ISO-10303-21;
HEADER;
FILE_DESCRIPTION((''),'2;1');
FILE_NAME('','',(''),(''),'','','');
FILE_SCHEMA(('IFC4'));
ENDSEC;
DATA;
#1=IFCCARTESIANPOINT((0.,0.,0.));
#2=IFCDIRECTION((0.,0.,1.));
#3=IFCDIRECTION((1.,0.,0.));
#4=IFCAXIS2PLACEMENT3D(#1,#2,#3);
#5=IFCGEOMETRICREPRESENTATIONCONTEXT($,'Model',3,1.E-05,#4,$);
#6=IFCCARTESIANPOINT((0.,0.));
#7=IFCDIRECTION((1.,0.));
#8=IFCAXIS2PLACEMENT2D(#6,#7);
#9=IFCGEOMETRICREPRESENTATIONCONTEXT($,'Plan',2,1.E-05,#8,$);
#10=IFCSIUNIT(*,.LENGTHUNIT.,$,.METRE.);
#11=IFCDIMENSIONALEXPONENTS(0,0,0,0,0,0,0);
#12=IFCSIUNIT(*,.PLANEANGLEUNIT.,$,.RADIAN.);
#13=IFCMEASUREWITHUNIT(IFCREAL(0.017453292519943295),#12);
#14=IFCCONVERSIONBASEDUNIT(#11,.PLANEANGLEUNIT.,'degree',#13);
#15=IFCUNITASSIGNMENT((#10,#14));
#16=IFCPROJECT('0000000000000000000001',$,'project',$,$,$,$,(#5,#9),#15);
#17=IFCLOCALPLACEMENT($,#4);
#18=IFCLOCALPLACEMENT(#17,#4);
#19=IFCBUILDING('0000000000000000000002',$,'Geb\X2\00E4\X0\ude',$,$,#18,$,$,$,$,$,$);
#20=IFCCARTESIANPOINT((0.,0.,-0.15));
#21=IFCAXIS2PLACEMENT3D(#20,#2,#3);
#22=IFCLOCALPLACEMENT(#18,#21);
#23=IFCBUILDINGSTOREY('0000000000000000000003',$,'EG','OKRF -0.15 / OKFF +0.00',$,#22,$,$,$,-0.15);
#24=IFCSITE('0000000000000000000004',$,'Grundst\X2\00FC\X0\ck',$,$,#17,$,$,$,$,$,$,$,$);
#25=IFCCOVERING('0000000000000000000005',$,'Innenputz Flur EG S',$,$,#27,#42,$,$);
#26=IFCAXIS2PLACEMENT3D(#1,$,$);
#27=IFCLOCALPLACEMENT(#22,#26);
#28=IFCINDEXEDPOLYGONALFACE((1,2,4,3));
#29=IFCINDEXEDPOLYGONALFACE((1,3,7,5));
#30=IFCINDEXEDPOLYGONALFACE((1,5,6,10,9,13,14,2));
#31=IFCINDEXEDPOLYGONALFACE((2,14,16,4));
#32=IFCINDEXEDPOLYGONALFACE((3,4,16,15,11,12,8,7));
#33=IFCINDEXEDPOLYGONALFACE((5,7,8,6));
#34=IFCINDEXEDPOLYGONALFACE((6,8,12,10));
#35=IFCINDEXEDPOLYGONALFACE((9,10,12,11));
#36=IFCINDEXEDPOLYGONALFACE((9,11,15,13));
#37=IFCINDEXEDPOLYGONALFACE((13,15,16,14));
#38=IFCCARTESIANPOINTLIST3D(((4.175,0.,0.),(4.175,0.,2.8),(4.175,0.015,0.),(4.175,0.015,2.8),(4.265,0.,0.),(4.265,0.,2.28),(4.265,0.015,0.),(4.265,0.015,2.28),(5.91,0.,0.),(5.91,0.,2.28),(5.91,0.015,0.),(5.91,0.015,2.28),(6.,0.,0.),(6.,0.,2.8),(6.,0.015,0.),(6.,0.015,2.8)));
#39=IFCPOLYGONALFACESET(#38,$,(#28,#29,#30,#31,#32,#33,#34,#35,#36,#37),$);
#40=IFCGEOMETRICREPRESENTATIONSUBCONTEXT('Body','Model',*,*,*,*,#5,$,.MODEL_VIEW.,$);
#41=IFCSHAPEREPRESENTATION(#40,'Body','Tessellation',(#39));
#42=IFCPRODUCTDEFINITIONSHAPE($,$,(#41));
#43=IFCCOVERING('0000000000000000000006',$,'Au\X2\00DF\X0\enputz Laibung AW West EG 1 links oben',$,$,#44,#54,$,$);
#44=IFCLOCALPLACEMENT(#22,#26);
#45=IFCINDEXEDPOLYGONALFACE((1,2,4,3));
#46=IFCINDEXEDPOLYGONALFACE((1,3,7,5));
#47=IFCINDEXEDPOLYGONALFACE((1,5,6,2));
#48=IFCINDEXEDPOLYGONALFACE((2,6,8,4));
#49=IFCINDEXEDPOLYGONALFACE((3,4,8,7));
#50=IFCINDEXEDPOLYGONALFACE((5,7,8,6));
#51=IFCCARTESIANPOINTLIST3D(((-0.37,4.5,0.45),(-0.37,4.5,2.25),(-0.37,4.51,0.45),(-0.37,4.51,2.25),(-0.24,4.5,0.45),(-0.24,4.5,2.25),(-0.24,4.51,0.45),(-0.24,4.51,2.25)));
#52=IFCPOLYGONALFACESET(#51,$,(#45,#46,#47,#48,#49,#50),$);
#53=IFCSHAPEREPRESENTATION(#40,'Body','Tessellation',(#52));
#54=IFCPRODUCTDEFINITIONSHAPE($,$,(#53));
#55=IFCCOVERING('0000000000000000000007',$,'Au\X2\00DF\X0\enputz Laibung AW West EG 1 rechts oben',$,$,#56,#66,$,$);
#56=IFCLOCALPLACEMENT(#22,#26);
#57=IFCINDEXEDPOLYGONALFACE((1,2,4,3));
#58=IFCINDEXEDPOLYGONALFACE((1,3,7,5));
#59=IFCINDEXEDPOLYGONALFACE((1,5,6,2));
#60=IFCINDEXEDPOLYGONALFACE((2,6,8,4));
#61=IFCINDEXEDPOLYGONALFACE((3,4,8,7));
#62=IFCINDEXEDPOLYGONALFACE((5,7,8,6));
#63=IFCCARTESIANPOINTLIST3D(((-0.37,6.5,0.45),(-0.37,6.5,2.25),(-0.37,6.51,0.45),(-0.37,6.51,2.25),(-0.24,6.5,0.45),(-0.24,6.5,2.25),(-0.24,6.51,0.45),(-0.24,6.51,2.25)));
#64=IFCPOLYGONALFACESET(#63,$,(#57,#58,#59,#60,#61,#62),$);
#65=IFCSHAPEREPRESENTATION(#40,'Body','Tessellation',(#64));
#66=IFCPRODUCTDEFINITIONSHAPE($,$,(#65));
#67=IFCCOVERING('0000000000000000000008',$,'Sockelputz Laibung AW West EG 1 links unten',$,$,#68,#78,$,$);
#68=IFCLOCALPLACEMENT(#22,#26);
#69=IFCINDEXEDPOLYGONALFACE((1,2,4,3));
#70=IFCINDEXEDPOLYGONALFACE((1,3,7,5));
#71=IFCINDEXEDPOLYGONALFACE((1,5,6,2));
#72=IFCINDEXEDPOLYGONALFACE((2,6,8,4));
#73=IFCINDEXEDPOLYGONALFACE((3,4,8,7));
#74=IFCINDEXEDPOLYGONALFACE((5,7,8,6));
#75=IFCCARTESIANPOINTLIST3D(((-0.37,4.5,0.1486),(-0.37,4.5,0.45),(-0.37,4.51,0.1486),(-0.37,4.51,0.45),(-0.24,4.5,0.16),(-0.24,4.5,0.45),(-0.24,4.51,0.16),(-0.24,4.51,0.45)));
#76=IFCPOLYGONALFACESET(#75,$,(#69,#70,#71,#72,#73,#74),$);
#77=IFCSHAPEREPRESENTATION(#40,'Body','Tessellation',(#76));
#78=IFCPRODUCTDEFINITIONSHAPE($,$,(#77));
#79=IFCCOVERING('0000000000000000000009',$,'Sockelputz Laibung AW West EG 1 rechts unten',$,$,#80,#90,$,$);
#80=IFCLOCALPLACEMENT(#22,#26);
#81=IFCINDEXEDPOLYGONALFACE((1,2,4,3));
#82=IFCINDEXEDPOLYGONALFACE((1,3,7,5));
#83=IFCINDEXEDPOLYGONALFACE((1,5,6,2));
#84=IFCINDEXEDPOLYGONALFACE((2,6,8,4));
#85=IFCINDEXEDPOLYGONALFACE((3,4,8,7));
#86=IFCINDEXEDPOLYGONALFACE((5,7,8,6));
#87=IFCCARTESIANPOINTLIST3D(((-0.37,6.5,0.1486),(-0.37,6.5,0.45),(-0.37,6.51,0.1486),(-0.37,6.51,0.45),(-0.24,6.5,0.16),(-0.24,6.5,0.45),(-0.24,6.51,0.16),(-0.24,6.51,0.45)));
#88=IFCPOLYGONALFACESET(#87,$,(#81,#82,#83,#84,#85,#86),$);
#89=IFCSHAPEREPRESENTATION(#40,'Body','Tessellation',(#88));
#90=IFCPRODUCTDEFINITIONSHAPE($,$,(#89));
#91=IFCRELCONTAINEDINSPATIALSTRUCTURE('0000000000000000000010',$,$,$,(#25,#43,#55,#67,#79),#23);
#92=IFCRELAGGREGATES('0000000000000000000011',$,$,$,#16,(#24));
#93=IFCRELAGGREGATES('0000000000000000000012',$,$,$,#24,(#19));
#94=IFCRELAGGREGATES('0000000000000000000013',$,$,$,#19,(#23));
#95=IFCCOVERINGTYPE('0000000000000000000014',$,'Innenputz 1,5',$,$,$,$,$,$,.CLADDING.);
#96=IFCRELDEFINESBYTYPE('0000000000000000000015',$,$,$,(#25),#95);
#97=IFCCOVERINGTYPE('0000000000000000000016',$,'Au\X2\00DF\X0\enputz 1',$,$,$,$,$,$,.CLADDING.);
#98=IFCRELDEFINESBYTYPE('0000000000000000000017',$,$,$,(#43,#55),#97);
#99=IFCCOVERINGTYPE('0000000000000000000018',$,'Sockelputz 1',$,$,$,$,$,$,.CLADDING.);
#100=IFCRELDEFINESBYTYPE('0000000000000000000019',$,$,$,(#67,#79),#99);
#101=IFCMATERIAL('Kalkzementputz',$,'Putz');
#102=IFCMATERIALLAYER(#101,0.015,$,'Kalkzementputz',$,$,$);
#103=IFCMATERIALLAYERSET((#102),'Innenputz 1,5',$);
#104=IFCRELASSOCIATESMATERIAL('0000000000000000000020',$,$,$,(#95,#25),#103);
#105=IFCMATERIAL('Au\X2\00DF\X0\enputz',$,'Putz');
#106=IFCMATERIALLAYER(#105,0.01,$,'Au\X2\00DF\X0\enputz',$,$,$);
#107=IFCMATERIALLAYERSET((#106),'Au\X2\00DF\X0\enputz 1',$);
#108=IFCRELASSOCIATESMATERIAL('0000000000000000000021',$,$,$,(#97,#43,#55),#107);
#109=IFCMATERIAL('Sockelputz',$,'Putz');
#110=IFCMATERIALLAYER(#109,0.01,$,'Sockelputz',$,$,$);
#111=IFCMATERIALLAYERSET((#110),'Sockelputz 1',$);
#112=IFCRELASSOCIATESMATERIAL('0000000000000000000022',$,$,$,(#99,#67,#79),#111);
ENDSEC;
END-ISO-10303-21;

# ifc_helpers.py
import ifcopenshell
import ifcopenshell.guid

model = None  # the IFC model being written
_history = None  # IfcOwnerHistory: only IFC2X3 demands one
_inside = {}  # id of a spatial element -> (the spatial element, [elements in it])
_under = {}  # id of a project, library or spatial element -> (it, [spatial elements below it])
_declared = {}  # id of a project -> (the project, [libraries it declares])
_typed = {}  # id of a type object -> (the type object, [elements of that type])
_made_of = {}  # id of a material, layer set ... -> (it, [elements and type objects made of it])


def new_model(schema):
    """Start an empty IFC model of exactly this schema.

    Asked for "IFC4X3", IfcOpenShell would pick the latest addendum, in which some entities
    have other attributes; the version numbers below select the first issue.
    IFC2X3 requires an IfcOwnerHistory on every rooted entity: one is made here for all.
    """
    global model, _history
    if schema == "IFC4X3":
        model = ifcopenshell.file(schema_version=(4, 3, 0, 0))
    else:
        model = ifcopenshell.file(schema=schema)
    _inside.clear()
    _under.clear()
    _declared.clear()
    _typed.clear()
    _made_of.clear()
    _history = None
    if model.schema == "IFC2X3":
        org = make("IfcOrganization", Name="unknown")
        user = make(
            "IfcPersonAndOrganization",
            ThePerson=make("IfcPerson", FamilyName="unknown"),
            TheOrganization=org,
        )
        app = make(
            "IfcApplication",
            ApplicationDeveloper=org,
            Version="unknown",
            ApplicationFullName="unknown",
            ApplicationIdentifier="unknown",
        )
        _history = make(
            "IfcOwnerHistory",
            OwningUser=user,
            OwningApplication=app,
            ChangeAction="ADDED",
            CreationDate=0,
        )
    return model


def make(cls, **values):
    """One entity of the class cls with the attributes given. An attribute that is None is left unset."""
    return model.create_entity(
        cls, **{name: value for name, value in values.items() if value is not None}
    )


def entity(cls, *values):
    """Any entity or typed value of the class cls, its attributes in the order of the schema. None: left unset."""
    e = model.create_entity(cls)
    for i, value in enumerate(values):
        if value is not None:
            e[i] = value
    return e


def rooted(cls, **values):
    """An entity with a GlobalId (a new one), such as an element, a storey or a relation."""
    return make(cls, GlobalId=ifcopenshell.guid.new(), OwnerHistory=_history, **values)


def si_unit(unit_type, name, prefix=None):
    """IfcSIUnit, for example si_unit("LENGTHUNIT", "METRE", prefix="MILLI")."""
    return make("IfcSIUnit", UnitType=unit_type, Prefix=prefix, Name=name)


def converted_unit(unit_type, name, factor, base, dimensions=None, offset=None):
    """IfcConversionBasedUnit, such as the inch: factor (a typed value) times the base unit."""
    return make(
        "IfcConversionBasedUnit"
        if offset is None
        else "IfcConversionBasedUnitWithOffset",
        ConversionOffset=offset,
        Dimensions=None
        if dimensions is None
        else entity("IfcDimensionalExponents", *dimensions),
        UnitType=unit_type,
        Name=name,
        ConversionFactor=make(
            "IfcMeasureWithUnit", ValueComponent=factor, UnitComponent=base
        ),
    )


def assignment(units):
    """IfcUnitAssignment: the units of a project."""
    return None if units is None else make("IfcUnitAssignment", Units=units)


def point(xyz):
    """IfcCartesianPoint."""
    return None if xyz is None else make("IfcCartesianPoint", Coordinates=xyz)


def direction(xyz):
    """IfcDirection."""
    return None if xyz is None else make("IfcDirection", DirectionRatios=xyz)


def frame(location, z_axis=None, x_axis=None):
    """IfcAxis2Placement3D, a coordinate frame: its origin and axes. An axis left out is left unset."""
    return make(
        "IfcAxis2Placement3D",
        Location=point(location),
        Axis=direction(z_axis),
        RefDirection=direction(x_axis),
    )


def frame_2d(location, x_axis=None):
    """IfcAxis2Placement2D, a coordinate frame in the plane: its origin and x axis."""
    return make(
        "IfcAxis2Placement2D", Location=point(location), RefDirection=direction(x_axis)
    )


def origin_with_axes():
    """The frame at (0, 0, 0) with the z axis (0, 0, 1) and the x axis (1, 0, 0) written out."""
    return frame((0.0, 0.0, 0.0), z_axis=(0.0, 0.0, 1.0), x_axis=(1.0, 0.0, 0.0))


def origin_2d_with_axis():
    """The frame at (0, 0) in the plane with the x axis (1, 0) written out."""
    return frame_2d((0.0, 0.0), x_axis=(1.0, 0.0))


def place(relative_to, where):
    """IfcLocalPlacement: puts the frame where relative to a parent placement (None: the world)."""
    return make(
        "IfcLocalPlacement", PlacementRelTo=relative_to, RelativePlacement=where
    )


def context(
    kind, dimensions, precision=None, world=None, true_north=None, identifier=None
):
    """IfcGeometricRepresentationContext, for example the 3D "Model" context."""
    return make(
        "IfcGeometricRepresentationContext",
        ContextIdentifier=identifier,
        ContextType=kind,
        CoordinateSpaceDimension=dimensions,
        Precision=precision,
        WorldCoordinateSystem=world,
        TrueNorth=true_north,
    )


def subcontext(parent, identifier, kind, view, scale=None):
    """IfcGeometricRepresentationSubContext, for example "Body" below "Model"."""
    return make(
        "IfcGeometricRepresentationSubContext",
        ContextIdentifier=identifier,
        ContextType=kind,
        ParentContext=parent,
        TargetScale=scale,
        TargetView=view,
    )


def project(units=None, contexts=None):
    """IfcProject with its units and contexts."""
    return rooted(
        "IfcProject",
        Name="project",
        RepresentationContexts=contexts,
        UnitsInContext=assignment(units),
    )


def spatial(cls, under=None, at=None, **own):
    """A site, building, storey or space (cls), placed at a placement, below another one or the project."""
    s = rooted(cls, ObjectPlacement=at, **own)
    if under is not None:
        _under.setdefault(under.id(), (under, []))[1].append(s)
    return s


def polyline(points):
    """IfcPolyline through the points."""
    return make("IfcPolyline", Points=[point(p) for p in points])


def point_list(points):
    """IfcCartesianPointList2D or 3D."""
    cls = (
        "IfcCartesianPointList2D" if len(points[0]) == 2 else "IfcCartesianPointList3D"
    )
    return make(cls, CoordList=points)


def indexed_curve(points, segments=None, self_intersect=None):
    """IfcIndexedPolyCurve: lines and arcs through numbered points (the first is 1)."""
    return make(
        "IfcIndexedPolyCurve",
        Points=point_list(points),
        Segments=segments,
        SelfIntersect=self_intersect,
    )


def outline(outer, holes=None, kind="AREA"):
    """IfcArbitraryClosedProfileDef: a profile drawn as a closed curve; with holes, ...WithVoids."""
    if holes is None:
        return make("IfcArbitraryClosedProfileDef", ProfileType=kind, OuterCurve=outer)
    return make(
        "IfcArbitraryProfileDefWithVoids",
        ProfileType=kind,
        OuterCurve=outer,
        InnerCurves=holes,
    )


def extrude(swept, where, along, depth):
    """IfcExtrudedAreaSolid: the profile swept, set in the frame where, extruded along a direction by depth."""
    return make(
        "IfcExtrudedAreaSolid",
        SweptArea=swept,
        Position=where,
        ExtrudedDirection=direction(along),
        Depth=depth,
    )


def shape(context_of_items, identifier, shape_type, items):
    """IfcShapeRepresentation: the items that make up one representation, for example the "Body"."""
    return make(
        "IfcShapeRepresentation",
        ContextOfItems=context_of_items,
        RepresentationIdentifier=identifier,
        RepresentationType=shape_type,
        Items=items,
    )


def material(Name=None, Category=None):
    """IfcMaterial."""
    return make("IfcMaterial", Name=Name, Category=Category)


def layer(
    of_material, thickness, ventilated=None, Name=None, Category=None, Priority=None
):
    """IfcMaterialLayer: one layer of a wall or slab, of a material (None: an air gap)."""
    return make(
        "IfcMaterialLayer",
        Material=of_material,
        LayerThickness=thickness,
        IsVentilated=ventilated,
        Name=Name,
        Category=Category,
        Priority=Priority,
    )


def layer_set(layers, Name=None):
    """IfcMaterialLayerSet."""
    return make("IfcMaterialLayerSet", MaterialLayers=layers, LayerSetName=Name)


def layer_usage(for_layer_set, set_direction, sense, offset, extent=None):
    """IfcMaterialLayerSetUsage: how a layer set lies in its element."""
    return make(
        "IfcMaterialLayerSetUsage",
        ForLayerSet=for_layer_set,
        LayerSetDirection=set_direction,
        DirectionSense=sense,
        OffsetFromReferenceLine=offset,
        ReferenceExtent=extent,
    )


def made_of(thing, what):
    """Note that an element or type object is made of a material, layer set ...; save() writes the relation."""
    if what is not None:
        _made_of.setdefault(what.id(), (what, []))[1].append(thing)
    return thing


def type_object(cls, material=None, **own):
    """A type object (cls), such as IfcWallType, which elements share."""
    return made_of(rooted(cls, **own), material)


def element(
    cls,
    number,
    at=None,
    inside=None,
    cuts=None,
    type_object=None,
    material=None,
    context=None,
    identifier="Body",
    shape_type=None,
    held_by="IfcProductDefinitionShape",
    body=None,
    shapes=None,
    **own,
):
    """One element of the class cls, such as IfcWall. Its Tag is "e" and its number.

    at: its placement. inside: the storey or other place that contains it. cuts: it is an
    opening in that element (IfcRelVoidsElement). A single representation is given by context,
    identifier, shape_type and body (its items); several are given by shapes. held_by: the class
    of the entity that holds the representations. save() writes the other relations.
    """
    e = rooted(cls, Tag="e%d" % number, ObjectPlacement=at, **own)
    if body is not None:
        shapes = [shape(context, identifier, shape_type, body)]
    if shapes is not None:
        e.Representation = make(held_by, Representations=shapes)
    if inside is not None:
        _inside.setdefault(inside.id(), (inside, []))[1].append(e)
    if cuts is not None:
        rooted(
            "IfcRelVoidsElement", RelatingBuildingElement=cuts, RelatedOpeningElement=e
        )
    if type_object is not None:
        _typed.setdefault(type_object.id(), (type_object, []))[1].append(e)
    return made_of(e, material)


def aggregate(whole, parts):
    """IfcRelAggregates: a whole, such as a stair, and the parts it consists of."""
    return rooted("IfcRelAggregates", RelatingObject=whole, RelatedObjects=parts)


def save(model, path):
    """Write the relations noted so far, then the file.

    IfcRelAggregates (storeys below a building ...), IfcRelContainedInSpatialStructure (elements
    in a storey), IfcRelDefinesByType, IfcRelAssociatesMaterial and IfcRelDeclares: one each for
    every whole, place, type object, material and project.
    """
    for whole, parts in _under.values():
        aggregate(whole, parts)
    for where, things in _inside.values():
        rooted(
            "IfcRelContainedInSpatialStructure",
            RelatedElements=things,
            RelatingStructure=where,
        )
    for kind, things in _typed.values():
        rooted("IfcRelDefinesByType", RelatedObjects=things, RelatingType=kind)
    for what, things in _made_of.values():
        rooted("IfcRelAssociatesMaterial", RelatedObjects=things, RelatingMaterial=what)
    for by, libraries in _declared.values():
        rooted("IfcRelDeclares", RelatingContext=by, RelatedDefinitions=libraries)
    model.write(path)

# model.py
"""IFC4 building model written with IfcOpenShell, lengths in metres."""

from ifc_helpers import new_model, entity, si_unit, converted_unit, frame, origin_with_axes, origin_2d_with_axis, place, context, subcontext, project, spatial, polyline, indexed_curve, outline, extrude, material, layer, layer_set, layer_usage, type_object, element, save


model = new_model("IFC4")

# Units and contexts
model_context = context("Model", 3, precision=1e-05, world=origin_with_axes())
plan_context = context("Plan", 2, precision=1e-05, world=origin_2d_with_axis())
body_context = subcontext(model_context, "Body", "Model", "MODEL_VIEW")
ifc_project = project(units=[si_unit("LENGTHUNIT", "METRE"), converted_unit("PLANEANGLEUNIT", "degree", entity("IfcReal", 0.017453292519943295), si_unit("PLANEANGLEUNIT", "RADIAN"), dimensions=[0, 0, 0, 0, 0, 0, 0])], contexts=[model_context, plan_context])

# Site, building, storey
site_placement = place(None, origin_with_axes())
site = spatial("IfcSite", under=ifc_project, at=site_placement, Name="Grundstück")
building_placement = place(site_placement, origin_with_axes())
building = spatial("IfcBuilding", under=site, at=building_placement, Name="Gebäude")
storey_placement = place(building_placement, frame((0.0, 0.0, -0.15), z_axis=(0.0, 0.0, 1.0), x_axis=(1.0, 0.0, 0.0)))
storey = spatial("IfcBuildingStorey", under=building, at=storey_placement, Name="EG", Description="OKRF -0.15 / OKFF +0.00", Elevation=-0.15)

# Shared definitions
ifc_material_1 = material(Name="Kalkzementputz", Category="Putz")
ifc_layer_1 = layer(ifc_material_1, 0.015, Name="Kalkzementputz")
ifc_layer_set_1 = layer_set([ifc_layer_1], Name="Innenputz 1,5")
covering_type_1 = type_object("IfcCoveringType", Name="Innenputz 1,5", PredefinedType="CLADDING", material=ifc_layer_set_1)

# Covering, opening
ifc_layer_usage_1 = layer_usage(ifc_layer_set_1, "AXIS2", "POSITIVE", 0.0)
covering_1_placement = place(storey_placement, frame((4.175, 0.0, 0.0), z_axis=(0.0, 0.0, 1.0), x_axis=(1.0, 0.0, 0.0)))
covering_1 = element("IfcCovering", 1, at=covering_1_placement, inside=storey, type_object=covering_type_1, material=ifc_layer_usage_1, Name="Innenputz Flur EG S", context=body_context, shape_type="SweptSolid", body=[
    extrude(outline(indexed_curve([(0.0, 0.0), (0.0, 0.015), (1.825, 0.015), (1.825, 0.0), (0.0, 0.0)], self_intersect=False)), origin_with_axes(), (0.0, 0.0, 1.0), 2.8),
])
opening_1_placement = place(covering_1_placement, frame((0.09, -0.05, 0.0), z_axis=(0.0, 0.0, 1.0), x_axis=(1.0, 0.0, 0.0)))
element("IfcOpeningElement", 2, at=opening_1_placement, cuts=covering_1, context=body_context, shape_type="SweptSolid", body=[
    extrude(outline(indexed_curve([(0.0, 0.0), (0.0, 0.115), (1.645, 0.115), (1.645, 0.0), (0.0, 0.0)], self_intersect=False)), origin_with_axes(), (0.0, 0.0, 1.0), 2.28),
])

# Coverings
ifc_material_2 = material(Name="Außenputz", Category="Putz")
ifc_layer_2 = layer(ifc_material_2, 0.01, Name="Außenputz")
ifc_layer_set_2 = layer_set([ifc_layer_2], Name="Außenputz 1")
ifc_layer_usage_2 = layer_usage(ifc_layer_set_2, "AXIS1", "POSITIVE", 4.5)
covering_type_2 = type_object("IfcCoveringType", Name="Außenputz 1", PredefinedType="CLADDING", material=ifc_layer_set_2)
covering_2_placement = place(storey_placement, frame((0.0, 0.0, 0.0), z_axis=(0.0, 0.0, 1.0), x_axis=(0.0, 1.0, 0.0)))
element("IfcCovering", 3, at=covering_2_placement, inside=storey, type_object=covering_type_2, material=ifc_layer_usage_2, Name="Außenputz Laibung AW West EG 1 links oben", context=body_context, shape_type="SweptSolid", body=[
    extrude(outline(polyline([(0.24, 0.45), (0.37, 0.45), (0.37, 2.25), (0.24, 2.25), (0.24, 0.45)])), frame((4.5, 0.0, 0.0), z_axis=(1.0, 0.0, 0.0), x_axis=(0.0, 1.0, 0.0)), (0.0, 0.0, 1.0), 0.01),
])
ifc_layer_usage_3 = layer_usage(ifc_layer_set_2, "AXIS1", "POSITIVE", 6.5)
covering_3_placement = place(storey_placement, frame((0.0, 0.0, 0.0), z_axis=(0.0, 0.0, 1.0), x_axis=(0.0, 1.0, 0.0)))
element("IfcCovering", 4, at=covering_3_placement, inside=storey, type_object=covering_type_2, material=ifc_layer_usage_3, Name="Außenputz Laibung AW West EG 1 rechts oben", context=body_context, shape_type="SweptSolid", body=[
    extrude(outline(polyline([(0.24, 0.45), (0.37, 0.45), (0.37, 2.25), (0.24, 2.25), (0.24, 0.45)])), frame((6.5, 0.0, 0.0), z_axis=(1.0, 0.0, 0.0), x_axis=(0.0, 1.0, 0.0)), (0.0, 0.0, 1.0), 0.01),
])
ifc_material_3 = material(Name="Sockelputz", Category="Putz")
ifc_layer_3 = layer(ifc_material_3, 0.01, Name="Sockelputz")
ifc_layer_set_3 = layer_set([ifc_layer_3], Name="Sockelputz 1")
ifc_layer_usage_4 = layer_usage(ifc_layer_set_3, "AXIS1", "POSITIVE", 4.5)
covering_type_3 = type_object("IfcCoveringType", Name="Sockelputz 1", PredefinedType="CLADDING", material=ifc_layer_set_3)
covering_4_placement = place(storey_placement, frame((0.0, 0.0, 0.0), z_axis=(0.0, 0.0, 1.0), x_axis=(0.0, 1.0, 0.0)))
element("IfcCovering", 5, at=covering_4_placement, inside=storey, type_object=covering_type_3, material=ifc_layer_usage_4, Name="Sockelputz Laibung AW West EG 1 links unten", context=body_context, shape_type="SweptSolid", body=[
    extrude(outline(polyline([(0.24, 0.16), (0.37, 0.1486), (0.37, 0.45), (0.24, 0.45), (0.24, 0.16)])), frame((4.5, 0.0, 0.0), z_axis=(1.0, 0.0, 0.0), x_axis=(0.0, 1.0, 0.0)), (0.0, 0.0, 1.0), 0.01),
])
ifc_layer_usage_5 = layer_usage(ifc_layer_set_3, "AXIS1", "POSITIVE", 6.5)
covering_5_placement = place(storey_placement, frame((0.0, 0.0, 0.0), z_axis=(0.0, 0.0, 1.0), x_axis=(0.0, 1.0, 0.0)))
element("IfcCovering", 6, at=covering_5_placement, inside=storey, type_object=covering_type_3, material=ifc_layer_usage_5, Name="Sockelputz Laibung AW West EG 1 rechts unten", context=body_context, shape_type="SweptSolid", body=[
    extrude(outline(polyline([(0.24, 0.16), (0.37, 0.1486), (0.37, 0.45), (0.24, 0.45), (0.24, 0.16)])), frame((6.5, 0.0, 0.0), z_axis=(1.0, 0.0, 0.0), x_axis=(0.0, 1.0, 0.0)), (0.0, 0.0, 1.0), 0.01),
])

save(model, "model.ifc")
